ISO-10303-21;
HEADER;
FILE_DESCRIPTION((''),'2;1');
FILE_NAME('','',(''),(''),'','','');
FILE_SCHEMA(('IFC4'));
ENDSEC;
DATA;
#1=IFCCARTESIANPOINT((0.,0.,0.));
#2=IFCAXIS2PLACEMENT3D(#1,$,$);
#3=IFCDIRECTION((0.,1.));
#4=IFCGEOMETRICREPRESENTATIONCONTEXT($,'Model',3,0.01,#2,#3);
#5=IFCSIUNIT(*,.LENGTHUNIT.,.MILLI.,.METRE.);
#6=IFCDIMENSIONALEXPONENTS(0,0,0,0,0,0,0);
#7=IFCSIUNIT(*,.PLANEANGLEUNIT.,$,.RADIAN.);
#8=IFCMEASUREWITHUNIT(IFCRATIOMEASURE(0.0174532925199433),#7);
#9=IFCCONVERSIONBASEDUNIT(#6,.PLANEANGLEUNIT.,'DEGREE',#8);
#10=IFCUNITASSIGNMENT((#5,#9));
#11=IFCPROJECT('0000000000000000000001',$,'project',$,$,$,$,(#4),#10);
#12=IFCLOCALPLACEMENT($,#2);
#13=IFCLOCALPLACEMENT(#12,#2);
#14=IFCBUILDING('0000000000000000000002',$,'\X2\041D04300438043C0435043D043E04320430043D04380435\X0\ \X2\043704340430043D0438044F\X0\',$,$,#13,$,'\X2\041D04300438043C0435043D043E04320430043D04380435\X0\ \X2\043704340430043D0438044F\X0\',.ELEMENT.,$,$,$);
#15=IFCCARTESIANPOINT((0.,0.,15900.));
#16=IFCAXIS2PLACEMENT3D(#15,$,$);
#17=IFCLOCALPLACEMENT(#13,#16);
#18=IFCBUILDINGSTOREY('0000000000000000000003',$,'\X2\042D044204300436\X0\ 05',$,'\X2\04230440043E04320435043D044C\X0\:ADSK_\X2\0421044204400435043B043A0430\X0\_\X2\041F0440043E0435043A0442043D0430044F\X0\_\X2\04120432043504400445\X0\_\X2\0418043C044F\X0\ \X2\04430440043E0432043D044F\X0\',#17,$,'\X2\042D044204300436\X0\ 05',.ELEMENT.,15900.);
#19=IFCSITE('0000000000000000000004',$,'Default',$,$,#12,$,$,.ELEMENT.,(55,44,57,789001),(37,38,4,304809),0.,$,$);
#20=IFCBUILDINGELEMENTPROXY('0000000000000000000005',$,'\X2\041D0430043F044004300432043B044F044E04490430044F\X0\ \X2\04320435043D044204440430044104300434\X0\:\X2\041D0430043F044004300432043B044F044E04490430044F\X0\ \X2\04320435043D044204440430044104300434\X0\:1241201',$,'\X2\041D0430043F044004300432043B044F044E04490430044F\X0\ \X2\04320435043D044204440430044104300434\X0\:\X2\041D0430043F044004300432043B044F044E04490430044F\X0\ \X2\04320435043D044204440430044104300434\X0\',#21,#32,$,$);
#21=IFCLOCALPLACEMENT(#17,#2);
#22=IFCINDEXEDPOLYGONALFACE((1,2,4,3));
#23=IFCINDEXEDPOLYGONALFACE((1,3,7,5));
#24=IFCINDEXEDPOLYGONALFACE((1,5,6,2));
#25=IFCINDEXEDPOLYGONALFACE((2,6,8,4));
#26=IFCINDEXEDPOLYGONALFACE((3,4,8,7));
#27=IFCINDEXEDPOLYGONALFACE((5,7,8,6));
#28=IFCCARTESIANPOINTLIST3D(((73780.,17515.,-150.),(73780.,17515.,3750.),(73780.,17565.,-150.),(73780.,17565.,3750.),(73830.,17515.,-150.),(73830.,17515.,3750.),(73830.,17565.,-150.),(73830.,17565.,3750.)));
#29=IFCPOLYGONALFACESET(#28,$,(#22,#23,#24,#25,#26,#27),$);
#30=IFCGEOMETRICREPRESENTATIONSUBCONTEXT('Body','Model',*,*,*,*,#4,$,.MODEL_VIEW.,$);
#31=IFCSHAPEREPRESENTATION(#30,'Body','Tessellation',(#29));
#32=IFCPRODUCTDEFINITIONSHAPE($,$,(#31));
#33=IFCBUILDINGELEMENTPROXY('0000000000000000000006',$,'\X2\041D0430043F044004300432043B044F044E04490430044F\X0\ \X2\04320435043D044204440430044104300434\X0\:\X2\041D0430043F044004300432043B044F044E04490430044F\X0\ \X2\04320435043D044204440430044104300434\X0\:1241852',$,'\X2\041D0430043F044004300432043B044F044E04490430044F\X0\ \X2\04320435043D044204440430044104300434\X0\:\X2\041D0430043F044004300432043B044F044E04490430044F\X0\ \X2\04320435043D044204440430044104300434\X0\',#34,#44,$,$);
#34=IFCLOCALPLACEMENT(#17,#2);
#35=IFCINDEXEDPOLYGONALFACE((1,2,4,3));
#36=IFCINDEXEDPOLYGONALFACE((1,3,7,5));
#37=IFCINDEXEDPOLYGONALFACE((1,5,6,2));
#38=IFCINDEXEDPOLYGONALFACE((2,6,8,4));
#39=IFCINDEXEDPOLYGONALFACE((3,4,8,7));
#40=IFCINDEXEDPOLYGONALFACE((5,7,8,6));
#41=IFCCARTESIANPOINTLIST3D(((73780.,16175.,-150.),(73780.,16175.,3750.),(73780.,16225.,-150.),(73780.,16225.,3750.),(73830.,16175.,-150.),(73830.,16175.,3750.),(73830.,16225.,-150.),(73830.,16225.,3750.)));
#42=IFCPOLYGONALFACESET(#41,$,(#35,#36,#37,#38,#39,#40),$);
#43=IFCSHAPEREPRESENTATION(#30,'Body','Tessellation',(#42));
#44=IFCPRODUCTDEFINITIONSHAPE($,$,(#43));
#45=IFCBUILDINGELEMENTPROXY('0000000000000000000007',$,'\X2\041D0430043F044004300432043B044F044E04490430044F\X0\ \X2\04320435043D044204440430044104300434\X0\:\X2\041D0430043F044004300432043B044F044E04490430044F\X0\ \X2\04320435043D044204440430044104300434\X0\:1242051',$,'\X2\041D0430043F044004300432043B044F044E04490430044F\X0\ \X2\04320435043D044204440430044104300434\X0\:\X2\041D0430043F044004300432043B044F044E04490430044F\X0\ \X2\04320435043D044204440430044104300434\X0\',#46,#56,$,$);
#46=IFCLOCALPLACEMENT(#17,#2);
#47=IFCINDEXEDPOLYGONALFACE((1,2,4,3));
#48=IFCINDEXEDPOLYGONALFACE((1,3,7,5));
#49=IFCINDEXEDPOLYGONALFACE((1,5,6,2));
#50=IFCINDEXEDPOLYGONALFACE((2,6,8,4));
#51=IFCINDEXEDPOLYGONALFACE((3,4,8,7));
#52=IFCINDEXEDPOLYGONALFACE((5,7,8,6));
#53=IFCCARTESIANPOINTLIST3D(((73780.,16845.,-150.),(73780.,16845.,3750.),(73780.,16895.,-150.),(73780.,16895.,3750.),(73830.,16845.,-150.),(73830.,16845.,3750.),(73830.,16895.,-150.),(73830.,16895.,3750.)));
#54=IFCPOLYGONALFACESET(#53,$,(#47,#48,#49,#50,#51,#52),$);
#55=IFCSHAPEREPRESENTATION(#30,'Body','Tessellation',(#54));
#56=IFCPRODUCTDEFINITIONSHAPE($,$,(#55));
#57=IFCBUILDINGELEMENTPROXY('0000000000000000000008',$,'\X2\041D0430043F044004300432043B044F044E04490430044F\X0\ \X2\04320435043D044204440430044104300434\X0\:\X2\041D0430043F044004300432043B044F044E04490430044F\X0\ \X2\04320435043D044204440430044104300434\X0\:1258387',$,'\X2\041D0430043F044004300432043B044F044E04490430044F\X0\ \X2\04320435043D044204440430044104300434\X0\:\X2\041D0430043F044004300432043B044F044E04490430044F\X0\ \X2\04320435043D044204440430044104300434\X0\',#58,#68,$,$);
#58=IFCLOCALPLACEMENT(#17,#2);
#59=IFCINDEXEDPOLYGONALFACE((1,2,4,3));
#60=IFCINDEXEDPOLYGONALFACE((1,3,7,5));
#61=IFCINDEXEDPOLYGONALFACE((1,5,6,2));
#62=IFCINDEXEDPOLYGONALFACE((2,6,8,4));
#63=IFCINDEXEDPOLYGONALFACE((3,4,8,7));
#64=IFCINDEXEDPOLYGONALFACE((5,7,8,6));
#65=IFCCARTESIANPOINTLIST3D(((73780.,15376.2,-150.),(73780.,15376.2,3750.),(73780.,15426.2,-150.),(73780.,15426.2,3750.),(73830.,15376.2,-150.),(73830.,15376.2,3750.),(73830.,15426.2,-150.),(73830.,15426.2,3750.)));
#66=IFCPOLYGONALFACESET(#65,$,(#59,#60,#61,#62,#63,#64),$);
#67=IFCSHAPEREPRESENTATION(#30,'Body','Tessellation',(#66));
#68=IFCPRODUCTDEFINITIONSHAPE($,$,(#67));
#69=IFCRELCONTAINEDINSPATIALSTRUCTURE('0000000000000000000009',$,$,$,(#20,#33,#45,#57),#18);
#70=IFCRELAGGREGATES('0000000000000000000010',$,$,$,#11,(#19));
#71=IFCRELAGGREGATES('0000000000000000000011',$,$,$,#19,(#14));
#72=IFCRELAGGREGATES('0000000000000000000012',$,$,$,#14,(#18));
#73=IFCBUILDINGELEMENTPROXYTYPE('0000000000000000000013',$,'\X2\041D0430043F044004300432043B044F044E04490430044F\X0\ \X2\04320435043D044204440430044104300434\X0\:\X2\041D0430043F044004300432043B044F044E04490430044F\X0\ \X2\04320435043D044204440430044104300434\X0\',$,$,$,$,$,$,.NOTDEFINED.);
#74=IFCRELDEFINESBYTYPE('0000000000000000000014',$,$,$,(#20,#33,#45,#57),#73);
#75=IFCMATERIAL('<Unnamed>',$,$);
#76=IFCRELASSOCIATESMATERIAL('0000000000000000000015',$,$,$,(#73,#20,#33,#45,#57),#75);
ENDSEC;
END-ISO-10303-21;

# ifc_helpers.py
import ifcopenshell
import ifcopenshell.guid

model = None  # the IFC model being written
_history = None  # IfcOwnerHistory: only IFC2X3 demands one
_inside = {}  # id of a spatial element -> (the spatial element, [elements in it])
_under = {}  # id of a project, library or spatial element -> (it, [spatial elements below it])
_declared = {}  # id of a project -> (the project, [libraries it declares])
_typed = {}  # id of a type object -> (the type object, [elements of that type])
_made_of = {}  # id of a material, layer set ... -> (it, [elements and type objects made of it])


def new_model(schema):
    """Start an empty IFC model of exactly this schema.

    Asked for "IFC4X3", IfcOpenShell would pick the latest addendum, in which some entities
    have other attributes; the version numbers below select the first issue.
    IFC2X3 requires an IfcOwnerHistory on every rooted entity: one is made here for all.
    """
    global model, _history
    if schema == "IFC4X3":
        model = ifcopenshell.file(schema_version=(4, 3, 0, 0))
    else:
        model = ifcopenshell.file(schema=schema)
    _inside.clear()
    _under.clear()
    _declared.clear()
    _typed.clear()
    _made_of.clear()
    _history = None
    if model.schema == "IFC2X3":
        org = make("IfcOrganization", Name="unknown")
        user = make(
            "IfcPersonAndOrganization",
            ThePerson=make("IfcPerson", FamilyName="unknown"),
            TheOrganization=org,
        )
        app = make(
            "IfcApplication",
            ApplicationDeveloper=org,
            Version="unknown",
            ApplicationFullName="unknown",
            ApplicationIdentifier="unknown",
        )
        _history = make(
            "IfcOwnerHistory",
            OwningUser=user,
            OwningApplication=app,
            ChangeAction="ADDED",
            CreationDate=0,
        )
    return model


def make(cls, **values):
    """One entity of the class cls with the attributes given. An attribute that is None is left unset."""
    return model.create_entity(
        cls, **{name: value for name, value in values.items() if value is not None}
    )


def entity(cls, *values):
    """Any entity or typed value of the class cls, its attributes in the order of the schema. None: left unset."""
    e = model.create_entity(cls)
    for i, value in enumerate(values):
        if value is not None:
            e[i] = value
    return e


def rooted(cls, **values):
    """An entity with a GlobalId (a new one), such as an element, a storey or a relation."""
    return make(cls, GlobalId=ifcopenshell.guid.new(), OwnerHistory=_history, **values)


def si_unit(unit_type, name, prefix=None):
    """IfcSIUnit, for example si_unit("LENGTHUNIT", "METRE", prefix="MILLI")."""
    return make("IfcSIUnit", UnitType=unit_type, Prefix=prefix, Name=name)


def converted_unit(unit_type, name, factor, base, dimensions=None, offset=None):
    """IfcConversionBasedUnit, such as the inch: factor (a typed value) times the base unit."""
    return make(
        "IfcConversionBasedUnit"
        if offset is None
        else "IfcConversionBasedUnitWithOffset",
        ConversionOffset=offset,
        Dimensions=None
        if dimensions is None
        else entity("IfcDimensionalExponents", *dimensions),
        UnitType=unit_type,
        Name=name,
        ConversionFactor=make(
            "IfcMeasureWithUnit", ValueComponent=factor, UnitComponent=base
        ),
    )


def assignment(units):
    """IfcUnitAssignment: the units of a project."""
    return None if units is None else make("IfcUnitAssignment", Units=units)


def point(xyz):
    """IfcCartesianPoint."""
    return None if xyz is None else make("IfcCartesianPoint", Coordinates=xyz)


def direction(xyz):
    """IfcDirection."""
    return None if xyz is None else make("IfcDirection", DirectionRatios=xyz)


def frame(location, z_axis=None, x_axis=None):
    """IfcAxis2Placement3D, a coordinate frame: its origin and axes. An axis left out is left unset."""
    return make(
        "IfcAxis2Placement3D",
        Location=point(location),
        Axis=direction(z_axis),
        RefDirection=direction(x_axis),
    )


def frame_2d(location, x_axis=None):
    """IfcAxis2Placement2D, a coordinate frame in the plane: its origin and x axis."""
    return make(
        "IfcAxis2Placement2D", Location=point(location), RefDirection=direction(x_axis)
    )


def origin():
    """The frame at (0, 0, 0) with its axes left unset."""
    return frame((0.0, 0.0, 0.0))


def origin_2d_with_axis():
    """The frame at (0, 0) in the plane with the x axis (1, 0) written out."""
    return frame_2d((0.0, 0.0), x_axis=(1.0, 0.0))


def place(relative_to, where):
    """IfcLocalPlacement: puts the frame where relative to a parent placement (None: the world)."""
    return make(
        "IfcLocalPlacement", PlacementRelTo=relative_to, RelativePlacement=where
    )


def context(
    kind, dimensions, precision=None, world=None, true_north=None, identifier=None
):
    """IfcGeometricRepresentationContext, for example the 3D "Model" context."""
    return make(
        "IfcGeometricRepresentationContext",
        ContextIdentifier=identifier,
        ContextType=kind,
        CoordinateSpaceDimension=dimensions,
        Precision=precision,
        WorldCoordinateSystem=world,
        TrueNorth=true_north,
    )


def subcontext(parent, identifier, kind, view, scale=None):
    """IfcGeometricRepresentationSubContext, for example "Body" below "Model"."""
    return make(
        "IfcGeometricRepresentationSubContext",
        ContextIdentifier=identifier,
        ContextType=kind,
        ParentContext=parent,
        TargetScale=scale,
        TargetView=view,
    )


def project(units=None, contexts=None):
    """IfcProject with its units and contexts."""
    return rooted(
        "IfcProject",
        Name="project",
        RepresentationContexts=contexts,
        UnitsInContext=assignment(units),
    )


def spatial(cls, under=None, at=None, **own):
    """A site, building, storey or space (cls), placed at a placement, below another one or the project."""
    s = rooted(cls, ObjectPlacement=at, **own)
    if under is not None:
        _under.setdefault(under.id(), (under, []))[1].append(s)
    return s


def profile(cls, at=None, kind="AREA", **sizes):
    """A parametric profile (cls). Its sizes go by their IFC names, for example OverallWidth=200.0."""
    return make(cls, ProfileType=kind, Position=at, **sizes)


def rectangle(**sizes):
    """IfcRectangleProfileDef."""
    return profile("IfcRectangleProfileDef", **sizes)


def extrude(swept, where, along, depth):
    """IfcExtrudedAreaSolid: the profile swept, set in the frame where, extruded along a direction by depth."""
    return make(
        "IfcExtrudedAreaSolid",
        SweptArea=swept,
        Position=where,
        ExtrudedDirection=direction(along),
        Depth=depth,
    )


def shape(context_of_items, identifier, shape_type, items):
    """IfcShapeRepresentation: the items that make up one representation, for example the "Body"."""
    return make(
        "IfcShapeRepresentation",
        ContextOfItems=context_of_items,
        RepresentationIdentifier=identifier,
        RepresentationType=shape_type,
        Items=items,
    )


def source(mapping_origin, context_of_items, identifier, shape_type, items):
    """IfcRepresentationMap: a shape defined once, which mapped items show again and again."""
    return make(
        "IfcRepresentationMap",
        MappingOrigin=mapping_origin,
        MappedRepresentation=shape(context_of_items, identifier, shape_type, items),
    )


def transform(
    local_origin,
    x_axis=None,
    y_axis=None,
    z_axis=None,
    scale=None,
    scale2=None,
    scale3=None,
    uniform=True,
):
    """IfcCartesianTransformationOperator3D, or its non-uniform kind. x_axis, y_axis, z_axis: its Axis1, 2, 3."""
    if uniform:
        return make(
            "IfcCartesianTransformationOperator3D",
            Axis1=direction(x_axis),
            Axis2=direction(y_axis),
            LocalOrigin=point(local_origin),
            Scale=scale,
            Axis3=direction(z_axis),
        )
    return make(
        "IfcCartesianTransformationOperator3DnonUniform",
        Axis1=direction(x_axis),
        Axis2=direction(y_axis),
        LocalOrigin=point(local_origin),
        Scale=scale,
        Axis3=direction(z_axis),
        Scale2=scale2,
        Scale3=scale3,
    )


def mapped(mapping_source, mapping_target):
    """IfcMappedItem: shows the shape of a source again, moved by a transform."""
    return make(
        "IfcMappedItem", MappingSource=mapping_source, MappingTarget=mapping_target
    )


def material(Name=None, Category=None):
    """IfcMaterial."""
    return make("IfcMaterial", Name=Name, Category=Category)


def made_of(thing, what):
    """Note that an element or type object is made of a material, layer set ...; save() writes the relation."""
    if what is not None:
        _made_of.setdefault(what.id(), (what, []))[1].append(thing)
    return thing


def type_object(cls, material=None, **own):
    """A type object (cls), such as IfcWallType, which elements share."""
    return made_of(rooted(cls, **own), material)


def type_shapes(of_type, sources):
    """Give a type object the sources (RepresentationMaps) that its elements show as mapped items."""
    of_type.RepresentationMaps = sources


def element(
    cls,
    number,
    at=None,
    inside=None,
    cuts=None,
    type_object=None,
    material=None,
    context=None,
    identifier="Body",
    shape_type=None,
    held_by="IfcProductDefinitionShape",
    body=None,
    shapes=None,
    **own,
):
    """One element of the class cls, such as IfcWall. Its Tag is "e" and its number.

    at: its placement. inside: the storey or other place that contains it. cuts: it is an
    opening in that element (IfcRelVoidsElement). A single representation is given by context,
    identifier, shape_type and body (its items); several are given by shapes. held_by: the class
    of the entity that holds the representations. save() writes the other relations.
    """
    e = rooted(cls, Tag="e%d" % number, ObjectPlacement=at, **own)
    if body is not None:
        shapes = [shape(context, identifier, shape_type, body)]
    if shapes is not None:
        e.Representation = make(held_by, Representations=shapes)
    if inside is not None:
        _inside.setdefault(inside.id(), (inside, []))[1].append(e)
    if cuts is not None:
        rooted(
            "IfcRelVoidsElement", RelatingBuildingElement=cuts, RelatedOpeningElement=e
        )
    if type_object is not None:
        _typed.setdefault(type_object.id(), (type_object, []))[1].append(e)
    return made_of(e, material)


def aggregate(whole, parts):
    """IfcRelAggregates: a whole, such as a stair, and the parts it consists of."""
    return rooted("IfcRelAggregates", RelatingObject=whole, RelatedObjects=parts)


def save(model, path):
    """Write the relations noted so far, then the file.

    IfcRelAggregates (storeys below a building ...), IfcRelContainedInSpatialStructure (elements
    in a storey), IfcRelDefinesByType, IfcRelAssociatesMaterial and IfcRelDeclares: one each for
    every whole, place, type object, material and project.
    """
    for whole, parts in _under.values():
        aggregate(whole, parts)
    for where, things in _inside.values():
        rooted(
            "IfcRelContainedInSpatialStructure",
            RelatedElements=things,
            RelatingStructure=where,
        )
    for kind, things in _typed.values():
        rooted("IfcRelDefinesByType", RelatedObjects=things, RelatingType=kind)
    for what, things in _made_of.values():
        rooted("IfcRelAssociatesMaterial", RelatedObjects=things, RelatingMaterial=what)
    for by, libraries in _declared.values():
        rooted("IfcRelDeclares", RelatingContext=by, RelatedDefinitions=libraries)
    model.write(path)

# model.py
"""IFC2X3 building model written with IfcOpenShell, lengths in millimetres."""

from ifc_helpers import new_model, entity, si_unit, converted_unit, direction, frame, origin, origin_2d_with_axis, place, context, subcontext, project, spatial, rectangle, extrude, source, transform, mapped, material, type_object, type_shapes, element, save


model = new_model("IFC2X3")

# Units and contexts
model_context = context("Model", 3, precision=0.01, world=origin(), true_north=direction((0.0, 1.0)))
body_context = subcontext(model_context, "Body", "Model", "MODEL_VIEW")
ifc_project = project(units=[si_unit("LENGTHUNIT", "METRE", prefix="MILLI"), converted_unit("PLANEANGLEUNIT", "DEGREE", entity("IfcRatioMeasure", 0.0174532925199433), si_unit("PLANEANGLEUNIT", "RADIAN"), dimensions=[0, 0, 0, 0, 0, 0, 0])], contexts=[model_context])

# Site, building, storey
site_placement = place(None, origin())
site = spatial("IfcSite", under=ifc_project, at=site_placement, Name="Default", CompositionType="ELEMENT", RefLatitude=(55, 44, 57, 789001), RefLongitude=(37, 38, 4, 304809), RefElevation=0.0)
building_placement = place(site_placement, origin())
building = spatial("IfcBuilding", under=site, at=building_placement, Name="Наименование здания", LongName="Наименование здания", CompositionType="ELEMENT")
storey_placement = place(building_placement, frame((0.0, 0.0, 15900.0)))
storey = spatial("IfcBuildingStorey", under=building, at=storey_placement, Name="Этаж 05", ObjectType="Уровень:ADSK_Стрелка_Проектная_Вверх_Имя уровня", LongName="Этаж 05", CompositionType="ELEMENT", Elevation=15900.0)

# Building element proxies
ifc_material_1 = material(Name="<Unnamed>")
building_element_proxy_type_1 = type_object("IfcBuildingElementProxyType", Name="Направляющая вентфасад:Направляющая вентфасад", PredefinedType="NOTDEFINED", material=ifc_material_1)
shared_shape_1 = source(origin(), body_context, "Body", "SweptSolid", [
    extrude(rectangle(XDim=50.0, YDim=50.0, at=origin_2d_with_axis()), frame((25.0, -25.0, 0.0), z_axis=(0.0, 0.0, 1.0), x_axis=(-1.0, 0.0, 0.0)), (0.0, 0.0, 1.0), 3900.0),
])
type_shapes(building_element_proxy_type_1, [shared_shape_1])
for number, where, z_axis, x_axis, name in (
    (1, (73780.0, 17515.0, -150.0), (0.0, 0.0, 1.0), (0.0, 1.0, 0.0), "Направляющая вентфасад:Направляющая вентфасад:1241201"),
    (2, (73780.0, 16175.0, -150.0), (0.0, 0.0, 1.0), (0.0, 1.0, 0.0), "Направляющая вентфасад:Направляющая вентфасад:1241852"),
    (3, (73780.0, 16845.0, -150.0), (0.0, 0.0, 1.0), (0.0, 1.0, 0.0), "Направляющая вентфасад:Направляющая вентфасад:1242051"),
    (4, (73780.0, 15376.2, -150.0), (0.0, 0.0, 1.0), (0.0, 1.0, 0.0), "Направляющая вентфасад:Направляющая вентфасад:1258387"),
):
    element("IfcBuildingElementProxy", number, at=place(storey_placement, frame(where, z_axis=z_axis, x_axis=x_axis)), inside=storey, type_object=building_element_proxy_type_1, material=ifc_material_1, Name=name, ObjectType="Направляющая вентфасад:Направляющая вентфасад", context=body_context, shape_type="MappedRepresentation", body=[
        mapped(shared_shape_1, transform((0.0, 0.0, 0.0), scale=1.0)),
    ])

save(model, "model.ifc")
